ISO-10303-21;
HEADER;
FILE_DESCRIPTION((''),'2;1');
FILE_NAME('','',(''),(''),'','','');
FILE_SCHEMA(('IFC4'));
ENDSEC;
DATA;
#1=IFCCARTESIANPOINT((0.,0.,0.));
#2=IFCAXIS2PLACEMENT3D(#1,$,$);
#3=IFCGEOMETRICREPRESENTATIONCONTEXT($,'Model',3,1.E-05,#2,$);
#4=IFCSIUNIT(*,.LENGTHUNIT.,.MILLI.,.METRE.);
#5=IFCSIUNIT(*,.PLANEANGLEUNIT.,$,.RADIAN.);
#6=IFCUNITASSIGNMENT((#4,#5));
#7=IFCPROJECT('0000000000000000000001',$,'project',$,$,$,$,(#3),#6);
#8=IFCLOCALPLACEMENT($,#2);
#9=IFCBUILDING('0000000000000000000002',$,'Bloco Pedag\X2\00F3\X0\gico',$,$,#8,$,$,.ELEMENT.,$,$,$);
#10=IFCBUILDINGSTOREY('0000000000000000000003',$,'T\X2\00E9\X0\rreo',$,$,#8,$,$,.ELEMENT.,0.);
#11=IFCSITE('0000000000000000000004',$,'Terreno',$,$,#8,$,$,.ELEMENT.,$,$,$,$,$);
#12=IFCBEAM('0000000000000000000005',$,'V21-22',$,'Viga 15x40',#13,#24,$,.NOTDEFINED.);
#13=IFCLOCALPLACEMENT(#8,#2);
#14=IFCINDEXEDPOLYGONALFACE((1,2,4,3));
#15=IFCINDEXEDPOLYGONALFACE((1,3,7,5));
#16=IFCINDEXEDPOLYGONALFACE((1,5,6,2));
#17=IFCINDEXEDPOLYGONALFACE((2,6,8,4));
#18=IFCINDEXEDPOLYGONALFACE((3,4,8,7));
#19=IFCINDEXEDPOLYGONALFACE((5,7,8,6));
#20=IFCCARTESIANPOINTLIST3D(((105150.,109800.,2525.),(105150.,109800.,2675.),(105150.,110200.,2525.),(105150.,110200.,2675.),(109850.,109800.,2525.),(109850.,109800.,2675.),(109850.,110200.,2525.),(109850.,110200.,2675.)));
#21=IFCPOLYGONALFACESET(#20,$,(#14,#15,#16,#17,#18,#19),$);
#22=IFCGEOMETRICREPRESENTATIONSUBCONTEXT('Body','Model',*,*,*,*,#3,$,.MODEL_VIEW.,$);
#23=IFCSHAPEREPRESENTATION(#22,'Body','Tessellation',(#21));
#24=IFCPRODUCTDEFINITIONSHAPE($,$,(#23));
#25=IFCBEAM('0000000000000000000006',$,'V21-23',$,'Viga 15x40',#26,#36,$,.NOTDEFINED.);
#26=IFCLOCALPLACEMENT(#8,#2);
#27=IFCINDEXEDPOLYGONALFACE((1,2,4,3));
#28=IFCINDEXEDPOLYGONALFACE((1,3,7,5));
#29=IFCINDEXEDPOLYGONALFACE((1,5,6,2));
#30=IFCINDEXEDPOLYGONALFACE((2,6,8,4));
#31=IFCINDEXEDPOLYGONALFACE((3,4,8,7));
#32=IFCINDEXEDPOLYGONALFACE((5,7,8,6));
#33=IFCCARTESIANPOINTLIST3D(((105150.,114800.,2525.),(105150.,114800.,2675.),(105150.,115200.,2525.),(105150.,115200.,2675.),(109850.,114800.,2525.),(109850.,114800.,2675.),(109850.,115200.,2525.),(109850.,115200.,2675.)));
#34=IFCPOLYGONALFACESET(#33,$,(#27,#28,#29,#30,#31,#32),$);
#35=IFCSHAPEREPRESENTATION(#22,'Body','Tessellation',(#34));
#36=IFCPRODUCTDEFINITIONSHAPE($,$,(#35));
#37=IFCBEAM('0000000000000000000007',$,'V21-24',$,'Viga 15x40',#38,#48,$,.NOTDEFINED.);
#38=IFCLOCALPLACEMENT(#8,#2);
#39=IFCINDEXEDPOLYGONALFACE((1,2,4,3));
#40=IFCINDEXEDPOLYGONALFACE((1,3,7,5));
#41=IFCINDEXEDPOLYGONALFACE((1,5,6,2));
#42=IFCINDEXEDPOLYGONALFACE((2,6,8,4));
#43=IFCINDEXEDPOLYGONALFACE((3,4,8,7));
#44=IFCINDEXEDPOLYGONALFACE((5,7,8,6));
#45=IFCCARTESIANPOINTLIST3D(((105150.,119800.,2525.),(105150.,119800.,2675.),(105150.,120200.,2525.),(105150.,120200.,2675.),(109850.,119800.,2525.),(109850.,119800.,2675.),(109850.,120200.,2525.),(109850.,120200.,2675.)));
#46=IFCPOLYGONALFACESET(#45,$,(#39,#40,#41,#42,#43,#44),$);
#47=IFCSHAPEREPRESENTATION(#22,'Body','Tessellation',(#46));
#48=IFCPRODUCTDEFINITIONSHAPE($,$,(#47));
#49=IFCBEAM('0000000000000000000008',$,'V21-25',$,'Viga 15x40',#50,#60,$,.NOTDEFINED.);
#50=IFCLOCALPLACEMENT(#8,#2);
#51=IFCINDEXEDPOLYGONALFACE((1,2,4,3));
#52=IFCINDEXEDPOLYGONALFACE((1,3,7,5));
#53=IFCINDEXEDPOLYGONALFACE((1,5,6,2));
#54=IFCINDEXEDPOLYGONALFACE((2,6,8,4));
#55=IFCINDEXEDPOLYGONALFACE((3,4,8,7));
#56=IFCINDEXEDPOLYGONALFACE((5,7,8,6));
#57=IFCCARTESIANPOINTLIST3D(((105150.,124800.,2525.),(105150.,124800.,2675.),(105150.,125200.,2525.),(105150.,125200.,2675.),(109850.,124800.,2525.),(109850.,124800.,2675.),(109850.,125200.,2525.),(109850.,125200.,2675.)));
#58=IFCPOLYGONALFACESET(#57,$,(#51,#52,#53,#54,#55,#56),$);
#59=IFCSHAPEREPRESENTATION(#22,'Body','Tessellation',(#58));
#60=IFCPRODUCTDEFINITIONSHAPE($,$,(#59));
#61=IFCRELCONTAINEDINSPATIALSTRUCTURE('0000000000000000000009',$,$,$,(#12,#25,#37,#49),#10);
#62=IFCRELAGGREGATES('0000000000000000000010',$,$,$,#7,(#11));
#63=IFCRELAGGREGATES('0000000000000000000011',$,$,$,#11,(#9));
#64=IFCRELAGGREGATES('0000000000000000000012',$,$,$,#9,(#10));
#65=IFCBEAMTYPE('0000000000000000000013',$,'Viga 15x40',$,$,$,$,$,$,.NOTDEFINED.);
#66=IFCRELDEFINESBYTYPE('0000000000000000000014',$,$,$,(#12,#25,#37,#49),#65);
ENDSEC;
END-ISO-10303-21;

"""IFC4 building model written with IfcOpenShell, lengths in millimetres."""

from ifc_helpers import new_model, si_unit, frame, origin, origin_2d, place, context, subcontext, project, spatial, rectangle, extrude, type_object, element, save


model = new_model("IFC4")

# Units and contexts
model_context = context("Model", 3, precision=1e-05, world=origin())
body_context = subcontext(model_context, "Body", "Model", "MODEL_VIEW")
ifc_project = project(units=[si_unit("LENGTHUNIT", "METRE", prefix="MILLI"), si_unit("PLANEANGLEUNIT", "RADIAN")], contexts=[model_context])

# Site, building, storey
placement = place(None, origin())
site = spatial("IfcSite", under=ifc_project, at=placement, Name="Terreno", CompositionType="ELEMENT")
building = spatial("IfcBuilding", under=site, at=placement, Name="Bloco Pedagógico", CompositionType="ELEMENT")
storey = spatial("IfcBuildingStorey", under=building, at=placement, Name="Térreo", CompositionType="ELEMENT", Elevation=0.0)

# Beams
beam_type = type_object("IfcBeamType", Name="Viga 15x40", PredefinedType="NOTDEFINED")
for number, where, z_axis, x_axis, name in (
    (1, (105150.0, 110000.0, 2600.0), (1.0, 0.0, 0.0), (0.0, 1.0, 0.0), "V21-22"),
    (2, (105150.0, 115000.0, 2600.0), (1.0, 0.0, 0.0), (0.0, 1.0, 0.0), "V21-23"),
    (3, (105150.0, 120000.0, 2600.0), (1.0, 0.0, 0.0), (0.0, 1.0, 0.0), "V21-24"),
    (4, (105150.0, 125000.0, 2600.0), (1.0, 0.0, 0.0), (0.0, 1.0, 0.0), "V21-25"),
):
    element("IfcBeam", number, at=place(None, frame(where, z_axis=z_axis, x_axis=x_axis)), inside=storey, type_object=beam_type, Name=name, ObjectType="Viga 15x40", PredefinedType="NOTDEFINED", context=body_context, shape_type="SweptSolid", body=[
        extrude(rectangle(XDim=400.0, YDim=150.0, at=origin_2d()), None, (0.0, 0.0, 1.0), 4700.0),
    ])

save(model, "model.ifc")
